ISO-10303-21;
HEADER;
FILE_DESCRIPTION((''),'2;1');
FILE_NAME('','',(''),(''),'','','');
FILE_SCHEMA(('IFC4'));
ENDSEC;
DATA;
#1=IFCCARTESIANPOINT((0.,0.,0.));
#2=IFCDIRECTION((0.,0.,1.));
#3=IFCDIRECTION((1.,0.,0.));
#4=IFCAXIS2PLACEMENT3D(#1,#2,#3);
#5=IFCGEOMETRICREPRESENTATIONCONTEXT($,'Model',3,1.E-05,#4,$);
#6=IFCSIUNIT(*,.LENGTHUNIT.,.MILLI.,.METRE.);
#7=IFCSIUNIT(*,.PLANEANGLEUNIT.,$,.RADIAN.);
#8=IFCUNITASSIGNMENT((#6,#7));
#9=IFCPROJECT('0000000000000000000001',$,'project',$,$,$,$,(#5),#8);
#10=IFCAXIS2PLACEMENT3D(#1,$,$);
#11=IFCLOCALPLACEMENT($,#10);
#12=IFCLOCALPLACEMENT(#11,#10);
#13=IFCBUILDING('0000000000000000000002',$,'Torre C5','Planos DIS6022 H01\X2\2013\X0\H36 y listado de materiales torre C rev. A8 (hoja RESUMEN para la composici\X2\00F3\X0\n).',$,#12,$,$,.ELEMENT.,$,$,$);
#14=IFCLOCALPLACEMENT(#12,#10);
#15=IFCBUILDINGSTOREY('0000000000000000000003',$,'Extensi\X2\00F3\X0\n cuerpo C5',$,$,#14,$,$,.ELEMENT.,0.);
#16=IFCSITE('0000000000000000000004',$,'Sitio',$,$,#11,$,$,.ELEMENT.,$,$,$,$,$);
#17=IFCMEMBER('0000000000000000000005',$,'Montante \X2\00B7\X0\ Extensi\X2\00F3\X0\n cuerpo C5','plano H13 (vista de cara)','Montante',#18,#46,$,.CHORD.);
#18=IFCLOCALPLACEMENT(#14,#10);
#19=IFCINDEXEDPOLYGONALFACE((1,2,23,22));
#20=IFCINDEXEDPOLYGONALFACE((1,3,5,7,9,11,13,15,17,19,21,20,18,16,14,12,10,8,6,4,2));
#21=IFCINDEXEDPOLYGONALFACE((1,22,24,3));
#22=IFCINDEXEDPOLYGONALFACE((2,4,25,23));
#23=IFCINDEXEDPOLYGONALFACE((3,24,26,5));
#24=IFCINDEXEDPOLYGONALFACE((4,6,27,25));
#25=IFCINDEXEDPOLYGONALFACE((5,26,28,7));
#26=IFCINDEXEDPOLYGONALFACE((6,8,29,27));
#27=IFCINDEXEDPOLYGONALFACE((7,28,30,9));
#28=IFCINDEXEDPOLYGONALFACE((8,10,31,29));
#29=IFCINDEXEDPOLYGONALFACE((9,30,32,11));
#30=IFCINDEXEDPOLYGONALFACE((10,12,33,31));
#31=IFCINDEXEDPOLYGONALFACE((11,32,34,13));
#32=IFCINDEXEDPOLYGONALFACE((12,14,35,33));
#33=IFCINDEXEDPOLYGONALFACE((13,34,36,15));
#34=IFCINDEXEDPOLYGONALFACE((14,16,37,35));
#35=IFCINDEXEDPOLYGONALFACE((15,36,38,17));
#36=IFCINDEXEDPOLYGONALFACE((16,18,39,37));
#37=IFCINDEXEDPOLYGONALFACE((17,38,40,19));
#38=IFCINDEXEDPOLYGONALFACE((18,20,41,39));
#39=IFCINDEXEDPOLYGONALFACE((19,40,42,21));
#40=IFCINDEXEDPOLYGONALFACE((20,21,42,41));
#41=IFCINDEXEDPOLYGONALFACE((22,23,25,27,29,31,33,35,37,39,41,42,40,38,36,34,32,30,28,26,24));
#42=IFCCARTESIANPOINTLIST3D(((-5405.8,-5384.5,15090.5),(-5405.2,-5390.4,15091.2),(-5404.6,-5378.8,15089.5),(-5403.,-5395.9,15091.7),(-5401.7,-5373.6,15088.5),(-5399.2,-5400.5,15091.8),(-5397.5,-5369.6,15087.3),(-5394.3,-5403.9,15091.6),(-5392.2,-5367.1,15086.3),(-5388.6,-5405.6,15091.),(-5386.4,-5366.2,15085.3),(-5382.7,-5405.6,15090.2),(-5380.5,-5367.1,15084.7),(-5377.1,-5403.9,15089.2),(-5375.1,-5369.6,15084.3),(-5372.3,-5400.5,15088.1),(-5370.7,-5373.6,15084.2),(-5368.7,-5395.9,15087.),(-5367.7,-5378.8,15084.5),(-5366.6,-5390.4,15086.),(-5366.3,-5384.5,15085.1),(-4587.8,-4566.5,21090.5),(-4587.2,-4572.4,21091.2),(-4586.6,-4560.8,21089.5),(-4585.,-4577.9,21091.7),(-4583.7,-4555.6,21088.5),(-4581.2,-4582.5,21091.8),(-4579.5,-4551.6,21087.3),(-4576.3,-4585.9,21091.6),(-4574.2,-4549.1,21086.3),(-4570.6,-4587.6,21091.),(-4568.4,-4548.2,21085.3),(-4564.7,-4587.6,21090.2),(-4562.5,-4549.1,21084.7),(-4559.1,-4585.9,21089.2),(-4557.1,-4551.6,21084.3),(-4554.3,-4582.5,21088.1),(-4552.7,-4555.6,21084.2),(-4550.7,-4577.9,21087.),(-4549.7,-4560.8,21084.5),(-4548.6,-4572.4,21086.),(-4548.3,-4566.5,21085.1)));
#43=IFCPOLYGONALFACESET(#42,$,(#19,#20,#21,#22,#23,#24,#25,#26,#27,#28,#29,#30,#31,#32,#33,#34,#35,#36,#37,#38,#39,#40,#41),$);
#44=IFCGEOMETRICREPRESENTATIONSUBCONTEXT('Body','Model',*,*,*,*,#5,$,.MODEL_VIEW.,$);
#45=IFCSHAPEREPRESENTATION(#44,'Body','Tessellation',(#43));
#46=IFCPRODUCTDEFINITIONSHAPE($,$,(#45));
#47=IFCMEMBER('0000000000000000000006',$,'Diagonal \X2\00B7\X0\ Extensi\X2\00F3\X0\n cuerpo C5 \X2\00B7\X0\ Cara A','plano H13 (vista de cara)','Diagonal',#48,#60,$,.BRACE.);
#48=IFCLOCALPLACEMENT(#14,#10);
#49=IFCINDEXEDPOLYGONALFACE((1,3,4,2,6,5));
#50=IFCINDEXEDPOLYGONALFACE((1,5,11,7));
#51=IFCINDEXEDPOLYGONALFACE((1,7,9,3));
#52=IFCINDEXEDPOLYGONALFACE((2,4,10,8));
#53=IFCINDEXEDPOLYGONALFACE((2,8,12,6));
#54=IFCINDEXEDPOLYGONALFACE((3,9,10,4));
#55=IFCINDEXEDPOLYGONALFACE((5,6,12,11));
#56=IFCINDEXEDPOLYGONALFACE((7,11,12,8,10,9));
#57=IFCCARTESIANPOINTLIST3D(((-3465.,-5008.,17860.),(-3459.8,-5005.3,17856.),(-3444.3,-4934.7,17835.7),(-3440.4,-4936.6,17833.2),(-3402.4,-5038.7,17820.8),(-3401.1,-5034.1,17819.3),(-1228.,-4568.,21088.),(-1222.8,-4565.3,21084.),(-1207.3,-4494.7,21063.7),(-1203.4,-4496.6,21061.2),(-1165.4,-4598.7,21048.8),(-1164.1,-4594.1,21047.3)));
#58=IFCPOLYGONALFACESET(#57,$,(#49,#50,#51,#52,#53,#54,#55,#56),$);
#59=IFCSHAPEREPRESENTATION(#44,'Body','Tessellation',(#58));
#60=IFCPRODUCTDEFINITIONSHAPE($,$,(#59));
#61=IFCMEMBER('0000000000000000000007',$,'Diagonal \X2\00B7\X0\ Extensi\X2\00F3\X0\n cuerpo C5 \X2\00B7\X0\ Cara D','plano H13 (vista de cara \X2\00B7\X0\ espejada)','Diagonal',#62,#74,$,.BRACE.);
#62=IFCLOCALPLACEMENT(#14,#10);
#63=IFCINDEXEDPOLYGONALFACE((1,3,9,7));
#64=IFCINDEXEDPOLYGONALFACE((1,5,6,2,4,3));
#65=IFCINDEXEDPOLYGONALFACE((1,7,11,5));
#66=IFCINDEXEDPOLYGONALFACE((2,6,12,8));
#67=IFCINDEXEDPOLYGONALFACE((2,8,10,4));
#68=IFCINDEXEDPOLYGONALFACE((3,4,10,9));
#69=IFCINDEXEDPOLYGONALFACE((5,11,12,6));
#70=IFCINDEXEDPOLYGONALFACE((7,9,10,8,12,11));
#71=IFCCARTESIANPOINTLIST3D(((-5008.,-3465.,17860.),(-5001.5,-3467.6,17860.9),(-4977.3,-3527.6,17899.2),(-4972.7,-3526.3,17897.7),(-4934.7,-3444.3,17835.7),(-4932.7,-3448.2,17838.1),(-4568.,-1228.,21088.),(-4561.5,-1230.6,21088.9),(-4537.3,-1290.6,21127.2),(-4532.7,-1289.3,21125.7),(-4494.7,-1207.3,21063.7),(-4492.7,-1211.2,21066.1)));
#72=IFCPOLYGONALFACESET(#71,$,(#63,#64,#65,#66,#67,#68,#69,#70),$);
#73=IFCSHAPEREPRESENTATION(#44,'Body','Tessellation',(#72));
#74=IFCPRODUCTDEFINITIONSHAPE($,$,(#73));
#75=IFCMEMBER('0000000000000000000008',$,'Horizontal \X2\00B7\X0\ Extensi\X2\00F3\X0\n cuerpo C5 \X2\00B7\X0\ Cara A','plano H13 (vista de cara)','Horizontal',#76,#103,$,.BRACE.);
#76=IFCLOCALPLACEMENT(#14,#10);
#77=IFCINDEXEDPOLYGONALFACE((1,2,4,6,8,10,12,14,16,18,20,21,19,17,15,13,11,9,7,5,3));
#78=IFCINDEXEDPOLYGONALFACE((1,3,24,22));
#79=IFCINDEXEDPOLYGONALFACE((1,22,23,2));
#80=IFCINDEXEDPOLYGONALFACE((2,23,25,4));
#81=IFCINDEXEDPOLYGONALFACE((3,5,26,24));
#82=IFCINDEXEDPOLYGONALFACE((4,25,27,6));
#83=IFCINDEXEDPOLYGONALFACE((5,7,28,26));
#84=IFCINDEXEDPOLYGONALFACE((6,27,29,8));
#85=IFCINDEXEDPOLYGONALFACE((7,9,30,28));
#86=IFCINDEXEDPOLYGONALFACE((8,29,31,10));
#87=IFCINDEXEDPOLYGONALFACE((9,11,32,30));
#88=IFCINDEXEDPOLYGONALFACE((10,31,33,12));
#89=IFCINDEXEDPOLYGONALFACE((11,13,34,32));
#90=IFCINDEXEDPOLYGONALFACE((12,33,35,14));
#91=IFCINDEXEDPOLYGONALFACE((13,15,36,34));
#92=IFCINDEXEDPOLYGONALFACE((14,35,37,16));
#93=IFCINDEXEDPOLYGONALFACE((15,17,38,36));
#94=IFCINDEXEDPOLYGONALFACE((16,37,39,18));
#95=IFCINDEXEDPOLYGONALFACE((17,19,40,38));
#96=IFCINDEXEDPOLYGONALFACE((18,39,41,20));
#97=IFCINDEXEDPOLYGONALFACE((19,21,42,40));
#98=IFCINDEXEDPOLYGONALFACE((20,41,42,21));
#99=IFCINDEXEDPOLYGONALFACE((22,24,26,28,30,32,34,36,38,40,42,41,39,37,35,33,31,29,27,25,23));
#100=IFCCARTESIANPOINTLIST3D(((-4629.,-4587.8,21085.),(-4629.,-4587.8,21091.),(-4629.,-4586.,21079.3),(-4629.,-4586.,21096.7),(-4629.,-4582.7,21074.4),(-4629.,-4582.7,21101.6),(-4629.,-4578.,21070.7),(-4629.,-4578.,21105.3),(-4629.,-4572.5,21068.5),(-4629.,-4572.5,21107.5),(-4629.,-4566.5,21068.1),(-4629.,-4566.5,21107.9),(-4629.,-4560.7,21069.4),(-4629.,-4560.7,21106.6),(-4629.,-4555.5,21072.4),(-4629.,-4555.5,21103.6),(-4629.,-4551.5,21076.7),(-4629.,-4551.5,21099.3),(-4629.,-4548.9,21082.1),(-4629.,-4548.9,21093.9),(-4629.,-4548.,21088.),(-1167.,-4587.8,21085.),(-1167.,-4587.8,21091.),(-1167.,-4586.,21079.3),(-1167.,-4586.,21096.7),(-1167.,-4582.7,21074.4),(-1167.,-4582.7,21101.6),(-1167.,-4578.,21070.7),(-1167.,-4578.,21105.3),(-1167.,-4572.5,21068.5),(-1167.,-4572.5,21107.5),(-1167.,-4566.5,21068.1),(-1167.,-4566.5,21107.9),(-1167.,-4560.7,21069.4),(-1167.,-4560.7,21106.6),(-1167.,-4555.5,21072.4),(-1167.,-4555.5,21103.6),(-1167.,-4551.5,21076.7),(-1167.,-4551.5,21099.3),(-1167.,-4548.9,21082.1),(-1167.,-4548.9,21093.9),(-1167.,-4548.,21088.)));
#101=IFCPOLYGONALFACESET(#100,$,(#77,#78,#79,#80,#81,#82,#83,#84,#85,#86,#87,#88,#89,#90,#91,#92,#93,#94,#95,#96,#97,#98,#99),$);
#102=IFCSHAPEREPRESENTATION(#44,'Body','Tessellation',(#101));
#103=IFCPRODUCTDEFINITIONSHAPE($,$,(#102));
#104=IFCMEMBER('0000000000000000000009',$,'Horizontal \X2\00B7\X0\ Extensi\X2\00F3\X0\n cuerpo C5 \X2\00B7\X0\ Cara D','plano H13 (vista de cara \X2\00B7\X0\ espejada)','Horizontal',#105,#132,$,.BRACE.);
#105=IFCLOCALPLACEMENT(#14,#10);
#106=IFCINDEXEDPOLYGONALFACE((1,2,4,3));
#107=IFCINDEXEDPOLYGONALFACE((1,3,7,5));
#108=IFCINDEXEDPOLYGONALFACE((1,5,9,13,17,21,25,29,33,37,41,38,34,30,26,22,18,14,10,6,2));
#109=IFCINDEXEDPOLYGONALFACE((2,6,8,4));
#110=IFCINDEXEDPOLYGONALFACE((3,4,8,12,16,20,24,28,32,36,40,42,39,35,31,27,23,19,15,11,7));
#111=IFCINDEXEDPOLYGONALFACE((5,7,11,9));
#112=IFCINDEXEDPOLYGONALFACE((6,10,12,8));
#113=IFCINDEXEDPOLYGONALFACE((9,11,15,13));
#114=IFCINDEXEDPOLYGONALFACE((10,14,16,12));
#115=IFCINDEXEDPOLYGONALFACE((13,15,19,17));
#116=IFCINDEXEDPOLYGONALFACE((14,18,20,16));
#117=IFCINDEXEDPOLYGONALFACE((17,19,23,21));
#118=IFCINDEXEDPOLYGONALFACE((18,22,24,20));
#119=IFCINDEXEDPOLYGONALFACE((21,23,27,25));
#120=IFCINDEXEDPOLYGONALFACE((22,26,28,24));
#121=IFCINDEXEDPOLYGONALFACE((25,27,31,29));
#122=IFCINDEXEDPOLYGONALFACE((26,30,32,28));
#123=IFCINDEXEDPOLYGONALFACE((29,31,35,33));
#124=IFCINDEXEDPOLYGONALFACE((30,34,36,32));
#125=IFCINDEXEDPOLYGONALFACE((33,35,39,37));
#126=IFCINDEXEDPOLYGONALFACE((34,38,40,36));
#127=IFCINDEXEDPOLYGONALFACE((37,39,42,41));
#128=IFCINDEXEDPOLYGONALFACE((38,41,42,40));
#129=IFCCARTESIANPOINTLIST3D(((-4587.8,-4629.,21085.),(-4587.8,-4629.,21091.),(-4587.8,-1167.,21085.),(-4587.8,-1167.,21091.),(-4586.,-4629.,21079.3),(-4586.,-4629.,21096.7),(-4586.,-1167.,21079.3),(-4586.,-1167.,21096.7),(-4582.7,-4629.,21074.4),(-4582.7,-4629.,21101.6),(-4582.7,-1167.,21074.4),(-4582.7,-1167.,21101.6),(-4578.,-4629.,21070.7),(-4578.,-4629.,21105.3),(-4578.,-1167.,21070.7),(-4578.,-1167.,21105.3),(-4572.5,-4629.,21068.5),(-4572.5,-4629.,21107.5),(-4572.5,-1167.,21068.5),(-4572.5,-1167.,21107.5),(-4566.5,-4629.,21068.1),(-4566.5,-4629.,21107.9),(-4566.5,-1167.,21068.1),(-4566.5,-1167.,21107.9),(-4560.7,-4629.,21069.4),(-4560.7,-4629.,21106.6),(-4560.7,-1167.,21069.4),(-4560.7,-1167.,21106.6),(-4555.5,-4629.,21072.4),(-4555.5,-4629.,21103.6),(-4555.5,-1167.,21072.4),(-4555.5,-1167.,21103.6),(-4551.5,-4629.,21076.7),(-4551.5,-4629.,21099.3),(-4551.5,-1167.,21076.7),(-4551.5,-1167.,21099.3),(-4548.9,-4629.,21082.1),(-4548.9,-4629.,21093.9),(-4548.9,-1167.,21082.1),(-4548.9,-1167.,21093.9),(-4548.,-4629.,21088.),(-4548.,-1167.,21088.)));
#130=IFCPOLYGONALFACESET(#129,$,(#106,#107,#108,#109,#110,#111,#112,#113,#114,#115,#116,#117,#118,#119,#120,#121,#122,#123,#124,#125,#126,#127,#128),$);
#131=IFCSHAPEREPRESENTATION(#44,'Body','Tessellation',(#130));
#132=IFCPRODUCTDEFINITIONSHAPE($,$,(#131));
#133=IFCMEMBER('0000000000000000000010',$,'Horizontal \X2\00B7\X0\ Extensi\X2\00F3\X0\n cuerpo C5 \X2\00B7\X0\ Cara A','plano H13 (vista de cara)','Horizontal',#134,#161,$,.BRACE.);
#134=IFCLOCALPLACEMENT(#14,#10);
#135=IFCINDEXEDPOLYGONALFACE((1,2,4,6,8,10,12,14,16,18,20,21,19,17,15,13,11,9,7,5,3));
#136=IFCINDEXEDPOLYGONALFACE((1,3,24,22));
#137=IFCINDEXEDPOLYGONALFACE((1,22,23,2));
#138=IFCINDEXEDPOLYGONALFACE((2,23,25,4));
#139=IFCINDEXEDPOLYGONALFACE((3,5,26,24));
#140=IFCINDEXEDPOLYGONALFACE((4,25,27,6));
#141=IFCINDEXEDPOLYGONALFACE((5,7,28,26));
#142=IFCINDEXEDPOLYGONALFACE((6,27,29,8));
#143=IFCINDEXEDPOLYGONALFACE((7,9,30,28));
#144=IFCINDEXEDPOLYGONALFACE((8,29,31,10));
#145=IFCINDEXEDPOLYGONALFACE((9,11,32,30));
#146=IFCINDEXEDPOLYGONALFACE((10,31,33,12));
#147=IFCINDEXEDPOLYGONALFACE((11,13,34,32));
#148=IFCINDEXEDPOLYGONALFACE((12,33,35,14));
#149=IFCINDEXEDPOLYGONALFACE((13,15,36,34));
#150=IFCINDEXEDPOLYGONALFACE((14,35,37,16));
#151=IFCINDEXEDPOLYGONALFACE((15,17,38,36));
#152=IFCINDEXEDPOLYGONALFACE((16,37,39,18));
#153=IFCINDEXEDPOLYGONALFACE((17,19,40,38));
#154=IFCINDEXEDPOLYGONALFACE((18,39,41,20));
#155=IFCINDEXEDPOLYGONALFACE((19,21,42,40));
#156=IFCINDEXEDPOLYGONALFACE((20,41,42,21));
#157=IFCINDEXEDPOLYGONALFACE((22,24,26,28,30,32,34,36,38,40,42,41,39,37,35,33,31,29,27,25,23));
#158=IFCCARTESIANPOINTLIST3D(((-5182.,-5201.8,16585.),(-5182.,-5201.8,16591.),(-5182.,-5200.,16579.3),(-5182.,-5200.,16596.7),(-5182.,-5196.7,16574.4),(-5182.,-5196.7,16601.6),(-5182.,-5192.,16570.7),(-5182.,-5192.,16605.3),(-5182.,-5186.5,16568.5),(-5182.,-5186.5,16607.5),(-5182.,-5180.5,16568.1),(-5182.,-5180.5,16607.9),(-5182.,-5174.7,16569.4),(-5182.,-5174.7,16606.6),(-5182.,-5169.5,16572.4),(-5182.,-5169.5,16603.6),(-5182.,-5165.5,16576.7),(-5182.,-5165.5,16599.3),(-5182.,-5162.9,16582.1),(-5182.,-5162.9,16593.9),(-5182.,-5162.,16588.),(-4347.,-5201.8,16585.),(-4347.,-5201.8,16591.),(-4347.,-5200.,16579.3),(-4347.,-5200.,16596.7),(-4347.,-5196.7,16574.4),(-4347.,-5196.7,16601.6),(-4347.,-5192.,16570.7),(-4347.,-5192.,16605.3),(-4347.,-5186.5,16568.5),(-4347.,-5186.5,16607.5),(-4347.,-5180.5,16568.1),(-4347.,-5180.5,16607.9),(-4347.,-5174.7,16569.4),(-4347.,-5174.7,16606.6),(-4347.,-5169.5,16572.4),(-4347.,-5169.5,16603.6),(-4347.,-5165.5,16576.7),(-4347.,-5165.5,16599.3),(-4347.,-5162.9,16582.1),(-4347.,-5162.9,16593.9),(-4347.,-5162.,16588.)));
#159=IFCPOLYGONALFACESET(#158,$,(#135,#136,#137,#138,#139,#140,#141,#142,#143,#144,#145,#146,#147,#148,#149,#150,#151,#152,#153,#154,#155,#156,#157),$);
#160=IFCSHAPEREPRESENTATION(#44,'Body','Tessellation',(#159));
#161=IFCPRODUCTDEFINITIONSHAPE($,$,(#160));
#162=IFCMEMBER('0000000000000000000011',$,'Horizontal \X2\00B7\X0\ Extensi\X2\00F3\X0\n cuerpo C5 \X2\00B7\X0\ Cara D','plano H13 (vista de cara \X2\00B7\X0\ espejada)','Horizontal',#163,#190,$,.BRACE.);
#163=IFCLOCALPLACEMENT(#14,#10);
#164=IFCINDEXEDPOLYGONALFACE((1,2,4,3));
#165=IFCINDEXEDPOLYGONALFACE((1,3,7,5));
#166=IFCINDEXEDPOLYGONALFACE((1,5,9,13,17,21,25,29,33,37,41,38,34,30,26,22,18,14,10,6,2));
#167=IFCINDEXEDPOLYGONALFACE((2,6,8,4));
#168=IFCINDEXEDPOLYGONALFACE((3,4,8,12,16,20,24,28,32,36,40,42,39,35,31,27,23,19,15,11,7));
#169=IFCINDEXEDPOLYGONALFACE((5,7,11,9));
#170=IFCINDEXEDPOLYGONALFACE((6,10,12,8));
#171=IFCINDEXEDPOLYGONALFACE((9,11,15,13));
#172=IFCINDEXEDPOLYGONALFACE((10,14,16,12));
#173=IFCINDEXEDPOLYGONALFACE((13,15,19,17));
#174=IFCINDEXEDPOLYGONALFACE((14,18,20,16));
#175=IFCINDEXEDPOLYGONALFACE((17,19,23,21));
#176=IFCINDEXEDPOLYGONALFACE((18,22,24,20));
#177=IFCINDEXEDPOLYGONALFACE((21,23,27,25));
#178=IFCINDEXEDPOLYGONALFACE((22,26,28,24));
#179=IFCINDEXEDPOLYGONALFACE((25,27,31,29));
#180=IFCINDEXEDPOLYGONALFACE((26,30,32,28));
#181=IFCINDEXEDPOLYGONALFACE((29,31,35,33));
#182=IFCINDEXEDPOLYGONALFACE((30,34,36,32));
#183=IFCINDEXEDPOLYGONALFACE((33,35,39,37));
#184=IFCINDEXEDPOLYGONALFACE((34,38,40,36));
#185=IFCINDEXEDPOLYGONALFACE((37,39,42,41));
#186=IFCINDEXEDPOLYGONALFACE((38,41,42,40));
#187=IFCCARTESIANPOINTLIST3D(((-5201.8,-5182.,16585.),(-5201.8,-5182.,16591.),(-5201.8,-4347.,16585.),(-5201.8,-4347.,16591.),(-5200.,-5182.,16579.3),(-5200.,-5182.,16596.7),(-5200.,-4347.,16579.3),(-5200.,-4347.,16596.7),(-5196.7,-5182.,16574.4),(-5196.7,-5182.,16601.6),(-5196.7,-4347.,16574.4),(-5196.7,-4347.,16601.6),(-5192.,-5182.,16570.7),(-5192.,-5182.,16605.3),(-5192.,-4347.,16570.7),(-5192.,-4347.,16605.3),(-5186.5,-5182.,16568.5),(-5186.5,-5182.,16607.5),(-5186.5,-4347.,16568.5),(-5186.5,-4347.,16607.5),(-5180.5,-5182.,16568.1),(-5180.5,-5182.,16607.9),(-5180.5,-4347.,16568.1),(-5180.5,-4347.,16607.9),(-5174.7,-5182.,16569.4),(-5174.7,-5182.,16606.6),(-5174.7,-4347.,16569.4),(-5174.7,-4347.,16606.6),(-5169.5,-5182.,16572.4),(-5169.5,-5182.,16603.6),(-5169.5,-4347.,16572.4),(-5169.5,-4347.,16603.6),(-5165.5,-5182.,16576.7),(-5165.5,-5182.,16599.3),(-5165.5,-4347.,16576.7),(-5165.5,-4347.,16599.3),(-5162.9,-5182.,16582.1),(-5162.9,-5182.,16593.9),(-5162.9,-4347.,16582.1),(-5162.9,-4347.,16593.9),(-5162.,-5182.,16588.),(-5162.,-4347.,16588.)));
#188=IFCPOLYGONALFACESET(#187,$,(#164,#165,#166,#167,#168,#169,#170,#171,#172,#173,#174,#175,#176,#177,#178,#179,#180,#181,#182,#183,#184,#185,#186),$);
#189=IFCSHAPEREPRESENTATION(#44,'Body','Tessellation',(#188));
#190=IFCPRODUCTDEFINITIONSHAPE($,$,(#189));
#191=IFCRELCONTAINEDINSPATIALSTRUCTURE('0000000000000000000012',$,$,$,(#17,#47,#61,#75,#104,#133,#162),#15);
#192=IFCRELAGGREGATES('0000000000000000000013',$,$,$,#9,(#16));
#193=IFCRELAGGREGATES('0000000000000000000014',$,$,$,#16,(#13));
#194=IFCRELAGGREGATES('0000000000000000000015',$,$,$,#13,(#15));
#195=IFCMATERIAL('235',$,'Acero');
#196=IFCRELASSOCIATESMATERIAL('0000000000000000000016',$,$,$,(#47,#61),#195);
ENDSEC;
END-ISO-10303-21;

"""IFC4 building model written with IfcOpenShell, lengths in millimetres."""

from ifc_helpers import new_model, si_unit, frame, frame_2d, origin, origin_with_axes, place, context, subcontext, project, spatial, circle, l_section, extrude, material, element, save


model = new_model("IFC4")

# Units and contexts
model_context = context("Model", 3, precision=1e-05, world=origin_with_axes())
body_context = subcontext(model_context, "Body", "Model", "MODEL_VIEW")
ifc_project = project(units=[si_unit("LENGTHUNIT", "METRE", prefix="MILLI"), si_unit("PLANEANGLEUNIT", "RADIAN")], contexts=[model_context])

# Site, building, storey
site_placement = place(None, origin())
site = spatial("IfcSite", under=ifc_project, at=site_placement, Name="Sitio", CompositionType="ELEMENT")
building_placement = place(site_placement, origin())
building = spatial("IfcBuilding", under=site, at=building_placement, Name="Torre C5", Description="Planos DIS6022 H01–H36 y listado de materiales torre C rev. A8 (hoja RESUMEN para la composición).", CompositionType="ELEMENT")
storey_placement = place(building_placement, origin())
storey = spatial("IfcBuildingStorey", under=building, at=storey_placement, Name="Extensión cuerpo C5", CompositionType="ELEMENT", Elevation=0.0)

# Members
member_placement = place(storey_placement, frame((-4568.0, -4568.0, 21088.0), z_axis=(-0.133868, -0.133868, -0.981916), x_axis=(-0.018083, 0.990999, -0.132641)))
element("IfcMember", 1, at=member_placement, inside=storey, Name="Montante · Extensión cuerpo C5", Description="plano H13 (vista de cara)", ObjectType="Montante", PredefinedType="CHORD", context=body_context, shape_type="SweptSolid", body=[
    extrude(circle(Radius=20.0), None, (0.0, 0.0, 1.0), 6110.5),
])
ifc_material = material(Name="235", Category="Acero")
for number, where, z_axis, x_axis, name, description in (
    (2, (-1228.0, -4568.0, 21088.0), (-0.566052, -0.111338, -0.816816), (0.258752, 0.916768, -0.304277), "Diagonal · Extensión cuerpo C5 · Cara A", "plano H13 (vista de cara)"),
    (3, (-4568.0, -1228.0, 21088.0), (-0.111338, -0.566052, -0.816816), (0.916768, 0.258752, -0.304277), "Diagonal · Extensión cuerpo C5 · Cara D", "plano H13 (vista de cara · espejada)"),
):
    element("IfcMember", number, at=place(storey_placement, frame(where, z_axis=z_axis, x_axis=x_axis)), inside=storey, material=ifc_material, Name=name, Description=description, ObjectType="Diagonal", PredefinedType="BRACE", context=body_context, shape_type="SweptSolid", body=[
        extrude(l_section(Depth=80.0, Width=80.0, Thickness=5.0, at=frame_2d((40.0, 40.0))), None, (0.0, 0.0, 1.0), 3951.9),
    ])
for number, where, z_axis, x_axis, name, description in (
    (4, (-4629.0, -4568.0, 21088.0), (1.0, 0.0, 0.0), (0.0, 1.0, 0.0), "Horizontal · Extensión cuerpo C5 · Cara A", "plano H13 (vista de cara)"),
    (5, (-4568.0, -4629.0, 21088.0), (0.0, 1.0, 0.0), (1.0, 0.0, 0.0), "Horizontal · Extensión cuerpo C5 · Cara D", "plano H13 (vista de cara · espejada)"),
):
    element("IfcMember", number, at=place(storey_placement, frame(where, z_axis=z_axis, x_axis=x_axis)), inside=storey, Name=name, Description=description, ObjectType="Horizontal", PredefinedType="BRACE", context=body_context, shape_type="SweptSolid", body=[
        extrude(circle(Radius=20.0), None, (0.0, 0.0, 1.0), 3462.0),
    ])
for number, where, z_axis, x_axis, name, description in (
    (6, (-4347.0, -5182.0, 16588.0), (-1.0, 0.0, 0.0), (0.0, 1.0, 0.0), "Horizontal · Extensión cuerpo C5 · Cara A", "plano H13 (vista de cara)"),
    (7, (-5182.0, -4347.0, 16588.0), (0.0, -1.0, 0.0), (1.0, 0.0, 0.0), "Horizontal · Extensión cuerpo C5 · Cara D", "plano H13 (vista de cara · espejada)"),
):
    element("IfcMember", number, at=place(storey_placement, frame(where, z_axis=z_axis, x_axis=x_axis)), inside=storey, Name=name, Description=description, ObjectType="Horizontal", PredefinedType="BRACE", context=body_context, shape_type="SweptSolid", body=[
        extrude(circle(Radius=20.0), None, (0.0, 0.0, 1.0), 835.0),
    ])

save(model, "model.ifc")
